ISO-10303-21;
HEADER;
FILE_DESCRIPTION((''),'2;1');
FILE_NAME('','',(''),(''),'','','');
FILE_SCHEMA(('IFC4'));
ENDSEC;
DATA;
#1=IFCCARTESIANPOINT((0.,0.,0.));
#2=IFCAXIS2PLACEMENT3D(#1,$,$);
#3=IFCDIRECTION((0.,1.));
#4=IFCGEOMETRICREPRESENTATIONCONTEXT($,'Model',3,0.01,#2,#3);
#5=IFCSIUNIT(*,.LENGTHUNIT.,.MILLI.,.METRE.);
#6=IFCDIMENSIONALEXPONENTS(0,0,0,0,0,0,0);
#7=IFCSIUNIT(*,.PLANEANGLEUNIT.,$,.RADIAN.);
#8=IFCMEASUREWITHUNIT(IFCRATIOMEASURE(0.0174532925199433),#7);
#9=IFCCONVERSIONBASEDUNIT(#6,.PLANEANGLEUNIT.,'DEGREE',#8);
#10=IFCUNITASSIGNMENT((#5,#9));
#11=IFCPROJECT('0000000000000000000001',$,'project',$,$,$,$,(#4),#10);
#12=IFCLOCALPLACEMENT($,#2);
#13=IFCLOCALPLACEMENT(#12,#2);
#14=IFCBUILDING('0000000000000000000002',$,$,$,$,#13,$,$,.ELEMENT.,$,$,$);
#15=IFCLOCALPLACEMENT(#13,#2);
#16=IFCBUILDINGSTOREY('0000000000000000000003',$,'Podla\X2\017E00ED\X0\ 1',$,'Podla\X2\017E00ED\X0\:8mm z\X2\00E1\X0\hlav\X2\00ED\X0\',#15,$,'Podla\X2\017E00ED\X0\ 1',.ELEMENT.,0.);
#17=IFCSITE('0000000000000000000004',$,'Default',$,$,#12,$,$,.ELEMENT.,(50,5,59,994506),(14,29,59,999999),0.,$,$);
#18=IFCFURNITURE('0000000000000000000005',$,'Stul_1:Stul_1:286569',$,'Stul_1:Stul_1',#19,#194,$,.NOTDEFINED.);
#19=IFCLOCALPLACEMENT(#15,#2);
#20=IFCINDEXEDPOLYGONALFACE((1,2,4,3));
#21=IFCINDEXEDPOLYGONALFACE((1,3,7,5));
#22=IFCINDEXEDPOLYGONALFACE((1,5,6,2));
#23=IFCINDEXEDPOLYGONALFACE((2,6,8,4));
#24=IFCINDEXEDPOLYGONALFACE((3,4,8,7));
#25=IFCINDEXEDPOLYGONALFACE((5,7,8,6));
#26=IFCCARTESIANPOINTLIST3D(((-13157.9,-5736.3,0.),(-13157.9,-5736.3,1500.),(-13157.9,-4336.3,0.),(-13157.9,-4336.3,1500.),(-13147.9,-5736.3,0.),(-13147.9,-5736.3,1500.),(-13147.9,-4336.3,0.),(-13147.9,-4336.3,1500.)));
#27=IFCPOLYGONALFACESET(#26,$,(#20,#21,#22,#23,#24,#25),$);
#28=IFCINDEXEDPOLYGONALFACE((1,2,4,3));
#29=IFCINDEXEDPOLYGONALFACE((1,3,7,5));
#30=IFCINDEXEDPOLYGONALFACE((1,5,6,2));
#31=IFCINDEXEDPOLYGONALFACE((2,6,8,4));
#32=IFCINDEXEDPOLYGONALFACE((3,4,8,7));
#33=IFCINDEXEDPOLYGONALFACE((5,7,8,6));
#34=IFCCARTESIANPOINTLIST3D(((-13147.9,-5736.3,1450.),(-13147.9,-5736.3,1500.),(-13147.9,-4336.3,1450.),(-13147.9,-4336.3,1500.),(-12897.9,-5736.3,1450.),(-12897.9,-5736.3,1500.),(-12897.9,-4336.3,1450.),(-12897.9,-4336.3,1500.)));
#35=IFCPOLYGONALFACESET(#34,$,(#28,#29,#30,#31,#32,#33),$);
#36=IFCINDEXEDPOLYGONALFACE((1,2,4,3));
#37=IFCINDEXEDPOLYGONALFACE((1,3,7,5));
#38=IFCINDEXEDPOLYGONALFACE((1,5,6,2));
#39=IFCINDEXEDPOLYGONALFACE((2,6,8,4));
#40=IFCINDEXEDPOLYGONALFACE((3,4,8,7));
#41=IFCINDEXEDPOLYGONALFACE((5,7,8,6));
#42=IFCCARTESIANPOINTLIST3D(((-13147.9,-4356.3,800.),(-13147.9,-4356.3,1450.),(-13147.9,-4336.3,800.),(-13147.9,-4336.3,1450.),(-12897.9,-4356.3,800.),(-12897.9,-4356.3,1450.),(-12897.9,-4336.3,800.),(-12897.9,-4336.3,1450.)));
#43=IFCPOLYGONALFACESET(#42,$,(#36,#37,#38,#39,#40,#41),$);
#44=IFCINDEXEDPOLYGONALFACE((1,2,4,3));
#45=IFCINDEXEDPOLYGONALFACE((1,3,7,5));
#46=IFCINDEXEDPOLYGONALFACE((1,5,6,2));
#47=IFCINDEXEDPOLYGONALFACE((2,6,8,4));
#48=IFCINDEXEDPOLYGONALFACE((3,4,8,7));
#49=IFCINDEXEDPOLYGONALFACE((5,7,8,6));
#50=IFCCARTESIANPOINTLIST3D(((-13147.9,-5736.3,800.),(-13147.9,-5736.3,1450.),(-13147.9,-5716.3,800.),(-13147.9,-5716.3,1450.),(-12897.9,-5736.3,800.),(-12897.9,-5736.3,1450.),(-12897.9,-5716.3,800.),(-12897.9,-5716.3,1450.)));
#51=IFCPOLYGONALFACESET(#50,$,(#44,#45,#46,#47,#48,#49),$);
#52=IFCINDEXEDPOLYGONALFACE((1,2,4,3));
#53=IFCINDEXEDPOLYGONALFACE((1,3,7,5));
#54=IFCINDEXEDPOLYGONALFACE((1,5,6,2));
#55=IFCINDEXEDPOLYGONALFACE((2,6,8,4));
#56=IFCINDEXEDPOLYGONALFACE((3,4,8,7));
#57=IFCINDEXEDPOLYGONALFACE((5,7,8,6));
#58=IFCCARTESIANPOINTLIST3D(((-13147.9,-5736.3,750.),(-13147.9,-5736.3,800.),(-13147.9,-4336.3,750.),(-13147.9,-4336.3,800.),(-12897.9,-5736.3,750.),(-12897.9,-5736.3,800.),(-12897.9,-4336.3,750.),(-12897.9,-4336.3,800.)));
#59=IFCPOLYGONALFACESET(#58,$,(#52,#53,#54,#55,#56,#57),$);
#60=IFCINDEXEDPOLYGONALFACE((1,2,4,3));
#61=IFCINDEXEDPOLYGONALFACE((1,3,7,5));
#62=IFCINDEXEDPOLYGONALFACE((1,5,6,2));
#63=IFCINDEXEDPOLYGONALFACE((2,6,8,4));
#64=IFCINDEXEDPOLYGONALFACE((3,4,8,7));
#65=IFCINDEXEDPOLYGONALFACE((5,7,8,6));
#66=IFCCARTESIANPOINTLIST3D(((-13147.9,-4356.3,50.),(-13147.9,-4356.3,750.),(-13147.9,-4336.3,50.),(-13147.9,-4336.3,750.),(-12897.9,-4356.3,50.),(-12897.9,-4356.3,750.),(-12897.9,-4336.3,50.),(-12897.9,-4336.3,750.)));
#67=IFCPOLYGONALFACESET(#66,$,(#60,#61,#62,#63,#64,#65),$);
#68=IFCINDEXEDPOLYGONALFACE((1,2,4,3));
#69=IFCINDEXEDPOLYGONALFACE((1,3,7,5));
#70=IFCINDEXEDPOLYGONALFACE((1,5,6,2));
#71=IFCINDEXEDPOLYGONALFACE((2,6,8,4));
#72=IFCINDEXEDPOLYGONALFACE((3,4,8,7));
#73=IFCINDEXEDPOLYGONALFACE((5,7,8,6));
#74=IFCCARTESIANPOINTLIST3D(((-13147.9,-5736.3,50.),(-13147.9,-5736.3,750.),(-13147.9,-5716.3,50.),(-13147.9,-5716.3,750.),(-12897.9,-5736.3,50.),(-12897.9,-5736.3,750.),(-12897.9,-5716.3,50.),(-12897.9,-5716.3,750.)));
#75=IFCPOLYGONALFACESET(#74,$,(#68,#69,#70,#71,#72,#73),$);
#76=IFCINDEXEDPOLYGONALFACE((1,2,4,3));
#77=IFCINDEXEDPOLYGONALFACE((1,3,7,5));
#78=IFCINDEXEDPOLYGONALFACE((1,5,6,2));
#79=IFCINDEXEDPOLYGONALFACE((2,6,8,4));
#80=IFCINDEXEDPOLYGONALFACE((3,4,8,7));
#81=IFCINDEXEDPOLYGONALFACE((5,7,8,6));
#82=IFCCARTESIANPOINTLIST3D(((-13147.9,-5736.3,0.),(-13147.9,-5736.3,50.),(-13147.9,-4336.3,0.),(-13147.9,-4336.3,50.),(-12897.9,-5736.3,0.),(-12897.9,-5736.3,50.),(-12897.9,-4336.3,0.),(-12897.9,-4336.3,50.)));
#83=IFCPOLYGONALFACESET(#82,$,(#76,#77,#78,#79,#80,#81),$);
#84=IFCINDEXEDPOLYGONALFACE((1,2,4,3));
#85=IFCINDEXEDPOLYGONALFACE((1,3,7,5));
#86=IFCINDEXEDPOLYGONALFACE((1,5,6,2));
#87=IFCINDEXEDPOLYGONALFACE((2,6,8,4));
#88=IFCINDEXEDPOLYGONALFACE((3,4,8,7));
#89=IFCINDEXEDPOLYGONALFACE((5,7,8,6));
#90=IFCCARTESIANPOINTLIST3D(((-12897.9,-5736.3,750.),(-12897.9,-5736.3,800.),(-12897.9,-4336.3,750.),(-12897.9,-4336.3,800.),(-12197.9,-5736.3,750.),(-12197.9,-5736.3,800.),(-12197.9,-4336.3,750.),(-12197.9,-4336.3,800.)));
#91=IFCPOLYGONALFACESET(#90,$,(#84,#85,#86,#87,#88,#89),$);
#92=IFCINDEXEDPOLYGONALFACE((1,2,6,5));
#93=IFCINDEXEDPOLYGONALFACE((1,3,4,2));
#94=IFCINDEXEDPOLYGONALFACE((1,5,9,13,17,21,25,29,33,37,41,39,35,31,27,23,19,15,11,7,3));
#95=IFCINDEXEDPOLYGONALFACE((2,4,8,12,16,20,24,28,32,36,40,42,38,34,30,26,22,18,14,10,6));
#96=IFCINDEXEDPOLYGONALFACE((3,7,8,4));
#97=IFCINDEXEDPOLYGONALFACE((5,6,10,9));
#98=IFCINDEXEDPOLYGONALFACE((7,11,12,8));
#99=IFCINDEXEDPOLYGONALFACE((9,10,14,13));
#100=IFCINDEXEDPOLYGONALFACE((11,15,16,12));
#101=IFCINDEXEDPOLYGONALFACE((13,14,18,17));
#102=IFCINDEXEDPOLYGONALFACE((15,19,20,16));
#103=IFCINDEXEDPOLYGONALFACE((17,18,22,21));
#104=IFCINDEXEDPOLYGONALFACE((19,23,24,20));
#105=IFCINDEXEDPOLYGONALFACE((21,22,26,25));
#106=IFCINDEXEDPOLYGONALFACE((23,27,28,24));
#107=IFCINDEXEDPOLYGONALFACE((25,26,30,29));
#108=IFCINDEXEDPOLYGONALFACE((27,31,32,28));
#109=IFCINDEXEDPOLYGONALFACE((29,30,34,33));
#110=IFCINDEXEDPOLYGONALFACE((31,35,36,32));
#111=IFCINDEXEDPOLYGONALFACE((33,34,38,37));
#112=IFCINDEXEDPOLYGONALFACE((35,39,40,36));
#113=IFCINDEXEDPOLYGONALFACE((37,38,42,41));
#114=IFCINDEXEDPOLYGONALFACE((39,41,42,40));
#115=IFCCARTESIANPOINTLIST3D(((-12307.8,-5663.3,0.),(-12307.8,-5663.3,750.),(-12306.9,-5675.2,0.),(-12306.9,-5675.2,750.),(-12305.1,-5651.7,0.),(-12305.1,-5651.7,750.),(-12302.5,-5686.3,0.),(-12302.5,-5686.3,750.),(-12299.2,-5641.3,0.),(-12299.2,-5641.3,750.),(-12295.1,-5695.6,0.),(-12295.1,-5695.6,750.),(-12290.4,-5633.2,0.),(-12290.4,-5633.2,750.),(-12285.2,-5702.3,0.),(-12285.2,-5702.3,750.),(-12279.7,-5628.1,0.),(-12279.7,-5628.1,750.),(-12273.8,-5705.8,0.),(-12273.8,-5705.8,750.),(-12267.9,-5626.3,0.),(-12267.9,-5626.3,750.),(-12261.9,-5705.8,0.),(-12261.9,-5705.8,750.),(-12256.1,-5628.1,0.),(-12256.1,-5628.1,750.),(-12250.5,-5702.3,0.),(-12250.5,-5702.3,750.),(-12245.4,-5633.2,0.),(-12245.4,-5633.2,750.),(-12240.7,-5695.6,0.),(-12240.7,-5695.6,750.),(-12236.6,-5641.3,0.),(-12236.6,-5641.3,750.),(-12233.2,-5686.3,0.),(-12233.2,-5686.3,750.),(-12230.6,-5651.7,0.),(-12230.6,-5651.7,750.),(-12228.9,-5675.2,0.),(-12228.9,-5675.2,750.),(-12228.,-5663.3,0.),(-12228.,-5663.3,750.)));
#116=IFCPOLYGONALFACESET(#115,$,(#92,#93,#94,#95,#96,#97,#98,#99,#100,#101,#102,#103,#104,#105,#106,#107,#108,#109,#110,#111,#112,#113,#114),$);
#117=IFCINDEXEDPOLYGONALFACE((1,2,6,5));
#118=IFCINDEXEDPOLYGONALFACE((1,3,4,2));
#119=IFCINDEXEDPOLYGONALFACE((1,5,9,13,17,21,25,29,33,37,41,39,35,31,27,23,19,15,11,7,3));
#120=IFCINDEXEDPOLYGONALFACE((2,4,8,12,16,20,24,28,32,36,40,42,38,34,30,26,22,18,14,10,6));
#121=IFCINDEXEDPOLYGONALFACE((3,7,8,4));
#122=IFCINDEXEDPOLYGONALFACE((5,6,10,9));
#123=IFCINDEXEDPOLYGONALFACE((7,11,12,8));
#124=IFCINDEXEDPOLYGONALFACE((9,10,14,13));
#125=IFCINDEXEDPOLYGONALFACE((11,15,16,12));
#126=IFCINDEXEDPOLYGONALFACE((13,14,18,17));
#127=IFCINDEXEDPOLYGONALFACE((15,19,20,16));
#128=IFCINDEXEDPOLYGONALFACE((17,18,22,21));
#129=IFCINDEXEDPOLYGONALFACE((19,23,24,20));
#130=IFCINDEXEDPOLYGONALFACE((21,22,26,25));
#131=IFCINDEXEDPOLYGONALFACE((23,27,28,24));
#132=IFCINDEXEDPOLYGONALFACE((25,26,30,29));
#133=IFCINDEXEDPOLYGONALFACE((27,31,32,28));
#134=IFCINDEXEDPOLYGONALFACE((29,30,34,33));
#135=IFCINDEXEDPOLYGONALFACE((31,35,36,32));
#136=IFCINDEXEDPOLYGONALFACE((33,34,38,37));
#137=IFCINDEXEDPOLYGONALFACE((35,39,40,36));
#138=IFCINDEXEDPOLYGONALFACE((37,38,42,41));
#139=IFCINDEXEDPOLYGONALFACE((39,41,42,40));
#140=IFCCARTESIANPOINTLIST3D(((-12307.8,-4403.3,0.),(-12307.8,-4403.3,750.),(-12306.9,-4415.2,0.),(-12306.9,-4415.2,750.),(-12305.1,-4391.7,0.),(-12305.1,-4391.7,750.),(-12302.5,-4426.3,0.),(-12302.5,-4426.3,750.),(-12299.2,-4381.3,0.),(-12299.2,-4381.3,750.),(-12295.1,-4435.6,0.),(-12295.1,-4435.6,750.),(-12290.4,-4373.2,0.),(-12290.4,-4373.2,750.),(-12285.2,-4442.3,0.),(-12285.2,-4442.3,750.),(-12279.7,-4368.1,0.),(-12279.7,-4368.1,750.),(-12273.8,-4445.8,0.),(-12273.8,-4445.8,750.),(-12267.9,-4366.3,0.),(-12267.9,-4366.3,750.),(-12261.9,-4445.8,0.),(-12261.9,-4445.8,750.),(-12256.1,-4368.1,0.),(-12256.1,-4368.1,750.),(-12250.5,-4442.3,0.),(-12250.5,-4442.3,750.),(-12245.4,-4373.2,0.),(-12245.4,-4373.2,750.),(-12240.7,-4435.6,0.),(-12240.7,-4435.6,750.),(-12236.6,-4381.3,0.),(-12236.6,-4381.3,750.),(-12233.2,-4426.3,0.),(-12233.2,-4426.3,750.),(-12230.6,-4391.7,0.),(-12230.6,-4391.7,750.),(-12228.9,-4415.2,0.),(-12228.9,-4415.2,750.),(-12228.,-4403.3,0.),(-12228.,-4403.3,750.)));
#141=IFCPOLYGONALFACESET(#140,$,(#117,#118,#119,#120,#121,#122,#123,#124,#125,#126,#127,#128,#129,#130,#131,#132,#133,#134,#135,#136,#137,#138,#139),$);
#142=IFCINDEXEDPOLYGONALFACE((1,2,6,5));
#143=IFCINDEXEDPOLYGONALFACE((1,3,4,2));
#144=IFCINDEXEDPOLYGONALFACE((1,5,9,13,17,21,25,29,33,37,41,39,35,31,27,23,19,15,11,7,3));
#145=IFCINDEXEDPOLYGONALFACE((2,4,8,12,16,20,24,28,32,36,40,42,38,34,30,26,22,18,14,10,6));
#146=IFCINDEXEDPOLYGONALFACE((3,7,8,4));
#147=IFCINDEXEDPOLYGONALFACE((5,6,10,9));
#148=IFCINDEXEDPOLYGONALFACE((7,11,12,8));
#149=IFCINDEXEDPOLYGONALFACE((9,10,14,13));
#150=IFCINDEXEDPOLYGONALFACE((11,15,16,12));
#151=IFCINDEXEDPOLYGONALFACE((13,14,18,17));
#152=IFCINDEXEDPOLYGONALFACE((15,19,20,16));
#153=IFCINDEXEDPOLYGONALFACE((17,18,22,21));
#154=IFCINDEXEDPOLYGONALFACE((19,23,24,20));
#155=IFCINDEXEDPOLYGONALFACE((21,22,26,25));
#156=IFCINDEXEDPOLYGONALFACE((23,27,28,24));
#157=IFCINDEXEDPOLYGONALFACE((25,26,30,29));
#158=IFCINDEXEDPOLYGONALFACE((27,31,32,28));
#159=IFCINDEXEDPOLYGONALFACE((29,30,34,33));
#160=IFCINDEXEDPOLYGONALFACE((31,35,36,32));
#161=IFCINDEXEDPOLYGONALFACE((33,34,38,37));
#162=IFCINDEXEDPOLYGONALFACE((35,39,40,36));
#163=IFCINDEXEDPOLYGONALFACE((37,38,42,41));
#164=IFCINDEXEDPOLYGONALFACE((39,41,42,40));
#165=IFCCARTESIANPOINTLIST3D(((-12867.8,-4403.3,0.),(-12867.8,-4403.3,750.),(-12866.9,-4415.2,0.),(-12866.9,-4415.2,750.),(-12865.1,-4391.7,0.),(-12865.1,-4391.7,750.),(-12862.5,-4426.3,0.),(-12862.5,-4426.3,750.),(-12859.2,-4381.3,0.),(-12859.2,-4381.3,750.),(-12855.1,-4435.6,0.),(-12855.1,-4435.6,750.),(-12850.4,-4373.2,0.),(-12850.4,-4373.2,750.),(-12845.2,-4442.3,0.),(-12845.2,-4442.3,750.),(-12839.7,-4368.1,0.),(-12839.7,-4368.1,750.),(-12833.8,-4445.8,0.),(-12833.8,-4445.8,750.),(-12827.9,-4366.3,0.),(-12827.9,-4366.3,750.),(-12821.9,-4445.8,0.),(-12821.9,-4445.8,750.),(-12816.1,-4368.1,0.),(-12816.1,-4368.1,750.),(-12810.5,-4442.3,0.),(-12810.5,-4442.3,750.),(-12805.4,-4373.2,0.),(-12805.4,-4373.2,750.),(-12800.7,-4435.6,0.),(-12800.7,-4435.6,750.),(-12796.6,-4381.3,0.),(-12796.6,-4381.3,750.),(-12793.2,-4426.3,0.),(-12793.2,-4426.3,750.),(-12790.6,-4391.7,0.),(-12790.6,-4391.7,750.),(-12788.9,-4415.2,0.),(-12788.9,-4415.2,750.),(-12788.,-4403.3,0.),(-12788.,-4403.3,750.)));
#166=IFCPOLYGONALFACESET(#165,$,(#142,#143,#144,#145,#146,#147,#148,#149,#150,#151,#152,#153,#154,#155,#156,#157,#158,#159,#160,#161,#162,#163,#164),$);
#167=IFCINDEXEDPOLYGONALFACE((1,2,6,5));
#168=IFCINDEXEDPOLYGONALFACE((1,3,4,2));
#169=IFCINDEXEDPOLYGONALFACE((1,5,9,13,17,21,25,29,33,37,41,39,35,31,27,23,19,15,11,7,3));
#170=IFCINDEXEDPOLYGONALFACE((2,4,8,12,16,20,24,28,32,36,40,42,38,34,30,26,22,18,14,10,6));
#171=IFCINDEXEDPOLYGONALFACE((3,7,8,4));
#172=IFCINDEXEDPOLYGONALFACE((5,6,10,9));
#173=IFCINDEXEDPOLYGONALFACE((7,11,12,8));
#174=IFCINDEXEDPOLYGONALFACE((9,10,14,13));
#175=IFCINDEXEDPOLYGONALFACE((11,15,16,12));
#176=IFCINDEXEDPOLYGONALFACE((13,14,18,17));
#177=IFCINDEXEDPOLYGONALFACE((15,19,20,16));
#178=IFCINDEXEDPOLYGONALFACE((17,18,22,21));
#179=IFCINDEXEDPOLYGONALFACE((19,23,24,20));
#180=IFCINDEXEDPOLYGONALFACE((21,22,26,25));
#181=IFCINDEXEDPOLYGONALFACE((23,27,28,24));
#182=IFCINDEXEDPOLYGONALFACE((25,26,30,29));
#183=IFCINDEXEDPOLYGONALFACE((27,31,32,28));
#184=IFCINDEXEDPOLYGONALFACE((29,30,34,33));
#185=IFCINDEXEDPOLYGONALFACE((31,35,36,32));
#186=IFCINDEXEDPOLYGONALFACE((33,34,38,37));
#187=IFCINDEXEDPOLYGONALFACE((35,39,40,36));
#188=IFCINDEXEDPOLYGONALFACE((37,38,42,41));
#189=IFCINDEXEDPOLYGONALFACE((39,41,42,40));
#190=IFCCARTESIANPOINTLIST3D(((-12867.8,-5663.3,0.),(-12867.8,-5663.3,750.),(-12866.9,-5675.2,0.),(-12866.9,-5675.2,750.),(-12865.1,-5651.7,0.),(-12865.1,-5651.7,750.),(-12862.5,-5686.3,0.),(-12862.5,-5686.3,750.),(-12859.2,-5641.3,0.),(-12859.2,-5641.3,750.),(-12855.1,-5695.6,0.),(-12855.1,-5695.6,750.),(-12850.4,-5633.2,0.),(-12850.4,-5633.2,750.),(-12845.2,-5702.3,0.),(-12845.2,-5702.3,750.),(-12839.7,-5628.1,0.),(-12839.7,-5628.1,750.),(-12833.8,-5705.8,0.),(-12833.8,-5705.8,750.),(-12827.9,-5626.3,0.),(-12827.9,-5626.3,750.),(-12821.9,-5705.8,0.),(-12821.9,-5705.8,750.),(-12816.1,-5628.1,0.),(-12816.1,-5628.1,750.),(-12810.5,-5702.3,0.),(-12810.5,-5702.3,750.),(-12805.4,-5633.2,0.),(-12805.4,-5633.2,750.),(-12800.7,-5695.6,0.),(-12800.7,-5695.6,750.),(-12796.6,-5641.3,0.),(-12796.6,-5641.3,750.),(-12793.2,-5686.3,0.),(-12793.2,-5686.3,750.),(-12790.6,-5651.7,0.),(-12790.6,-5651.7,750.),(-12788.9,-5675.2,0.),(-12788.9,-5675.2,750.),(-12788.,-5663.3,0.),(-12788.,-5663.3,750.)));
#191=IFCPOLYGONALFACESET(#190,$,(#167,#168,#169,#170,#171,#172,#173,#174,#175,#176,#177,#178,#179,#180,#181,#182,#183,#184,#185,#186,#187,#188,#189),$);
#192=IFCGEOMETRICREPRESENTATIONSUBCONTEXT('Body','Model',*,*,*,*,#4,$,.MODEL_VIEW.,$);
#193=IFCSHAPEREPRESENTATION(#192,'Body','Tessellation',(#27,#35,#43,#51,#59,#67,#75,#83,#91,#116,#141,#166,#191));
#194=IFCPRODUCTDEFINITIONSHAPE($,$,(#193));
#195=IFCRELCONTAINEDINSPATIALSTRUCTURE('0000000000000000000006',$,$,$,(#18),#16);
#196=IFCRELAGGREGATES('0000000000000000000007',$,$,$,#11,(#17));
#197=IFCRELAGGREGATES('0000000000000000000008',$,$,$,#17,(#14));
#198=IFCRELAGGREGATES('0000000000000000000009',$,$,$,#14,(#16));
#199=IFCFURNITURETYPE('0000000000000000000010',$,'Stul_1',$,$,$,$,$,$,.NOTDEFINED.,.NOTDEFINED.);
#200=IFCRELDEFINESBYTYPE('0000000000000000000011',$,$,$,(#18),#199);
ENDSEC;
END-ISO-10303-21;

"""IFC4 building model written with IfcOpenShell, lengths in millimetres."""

from ifc_helpers import new_model, entity, si_unit, converted_unit, direction, frame, frame_2d, origin, origin_2d_with_axis, place, context, subcontext, project, spatial, rectangle, circle, extrude, source, transform, mapped, type_object, type_shapes, element, save


model = new_model("IFC4")

# Units and contexts
model_context = context("Model", 3, precision=0.01, world=origin(), true_north=direction((0.0, 1.0)))
body_context = subcontext(model_context, "Body", "Model", "MODEL_VIEW")
ifc_project = project(units=[si_unit("LENGTHUNIT", "METRE", prefix="MILLI"), converted_unit("PLANEANGLEUNIT", "DEGREE", entity("IfcRatioMeasure", 0.0174532925199433), si_unit("PLANEANGLEUNIT", "RADIAN"), dimensions=[0, 0, 0, 0, 0, 0, 0])], contexts=[model_context])

# Site, building, storey
site_placement = place(None, origin())
site = spatial("IfcSite", under=ifc_project, at=site_placement, Name="Default", CompositionType="ELEMENT", RefLatitude=(50, 5, 59, 994506), RefLongitude=(14, 29, 59, 999999), RefElevation=0.0)
building_placement = place(site_placement, origin())
building = spatial("IfcBuilding", under=site, at=building_placement, CompositionType="ELEMENT")
storey_placement = place(building_placement, origin())
storey = spatial("IfcBuildingStorey", under=building, at=storey_placement, Name="Podlaží 1", ObjectType="Podlaží:8mm záhlaví", LongName="Podlaží 1", CompositionType="ELEMENT", Elevation=0.0)

# Furniture
furniture_type = type_object("IfcFurnitureType", Name="Stul_1", AssemblyPlace="NOTDEFINED", PredefinedType="NOTDEFINED")
shared_shape_1 = source(origin(), body_context, "Body", "SweptSolid", [
    extrude(rectangle(XDim=1400.0, YDim=10.0, at=origin_2d_with_axis()), frame((0.0, 605.0, 0.0), z_axis=(0.0, 0.0, 1.0), x_axis=(-1.0, 0.0, 0.0)), (0.0, 0.0, 1.0), 1500.0),
    extrude(rectangle(XDim=1400.0, YDim=250.0, at=frame_2d((0.0, 0.0), x_axis=(1.0, 0.0))), frame((0.0, 475.0, 1450.0), z_axis=(0.0, 0.0, 1.0), x_axis=(-1.0, 0.0, 0.0)), (0.0, 0.0, 1.0), 50.0),
    extrude(rectangle(XDim=20.0, YDim=250.0, at=origin_2d_with_axis()), frame((690.0, 475.0, 800.0), z_axis=(0.0, 0.0, 1.0), x_axis=(-1.0, 0.0, 0.0)), (0.0, 0.0, 1.0), 650.0),
    extrude(rectangle(XDim=20.0, YDim=250.0, at=frame_2d((0.0, 0.0), x_axis=(1.0, 0.0))), frame((-690.0, 475.0, 800.0), z_axis=(0.0, 0.0, 1.0), x_axis=(-1.0, 0.0, 0.0)), (0.0, 0.0, 1.0), 650.0),
    extrude(rectangle(XDim=1400.0, YDim=250.0, at=origin_2d_with_axis()), frame((0.0, 475.0, 750.0), z_axis=(0.0, 0.0, 1.0), x_axis=(-1.0, 0.0, 0.0)), (0.0, 0.0, 1.0), 50.0),
    extrude(rectangle(XDim=20.0, YDim=250.0, at=origin_2d_with_axis()), frame((690.0, 475.0, 50.0), z_axis=(0.0, 0.0, 1.0), x_axis=(-1.0, 0.0, 0.0)), (0.0, 0.0, 1.0), 700.0),
    extrude(rectangle(XDim=20.0, YDim=250.0, at=frame_2d((0.0, 0.0), x_axis=(1.0, 0.0))), frame((-690.0, 475.0, 50.0), z_axis=(0.0, 0.0, 1.0), x_axis=(-1.0, 0.0, 0.0)), (0.0, 0.0, 1.0), 700.0),
    extrude(rectangle(XDim=1400.0, YDim=250.0, at=origin_2d_with_axis()), frame((0.0, 475.0, 0.0), z_axis=(0.0, 0.0, 1.0), x_axis=(-1.0, 0.0, 0.0)), (0.0, 0.0, 1.0), 50.0),
    extrude(rectangle(XDim=1400.0, YDim=700.0, at=origin_2d_with_axis()), frame((0.0, 0.0, 750.0), z_axis=(0.0, 0.0, 1.0), x_axis=(-1.0, 0.0, 0.0)), (0.0, 0.0, 1.0), 50.0),
    extrude(circle(Radius=40.0, at=frame_2d((0.0, 0.0), x_axis=(1.0, 0.0))), frame((-630.0, -280.0, 0.0)), (0.0, 0.0, 1.0), 750.0),
    extrude(circle(Radius=40.0, at=frame_2d((0.0, 0.0), x_axis=(1.0, 0.0))), frame((630.0, -280.0, 0.0)), (0.0, 0.0, 1.0), 750.0),
    extrude(circle(Radius=40.0, at=frame_2d((0.0, 0.0), x_axis=(1.0, 0.0))), frame((630.0, 280.0, 0.0)), (0.0, 0.0, 1.0), 750.0),
    extrude(circle(Radius=40.0, at=frame_2d((0.0, 0.0), x_axis=(1.0, 0.0))), frame((-630.0, 280.0, 0.0)), (0.0, 0.0, 1.0), 750.0),
])
type_shapes(furniture_type, [shared_shape_1])
for number, where, z_axis, x_axis, name in (
    (1, (-12547.9, -5036.3, 0.0), (0.0, 0.0, 1.0), (0.0, 1.0, 0.0), "Stul_1:Stul_1:286569"),
):
    element("IfcFurniture", number, at=place(storey_placement, frame(where, z_axis=z_axis, x_axis=x_axis)), inside=storey, type_object=furniture_type, Name=name, ObjectType="Stul_1:Stul_1", PredefinedType="NOTDEFINED", context=body_context, shape_type="MappedRepresentation", body=[
        mapped(shared_shape_1, transform((0.0, 0.0, 0.0), scale=1.0)),
    ])

save(model, "model.ifc")
